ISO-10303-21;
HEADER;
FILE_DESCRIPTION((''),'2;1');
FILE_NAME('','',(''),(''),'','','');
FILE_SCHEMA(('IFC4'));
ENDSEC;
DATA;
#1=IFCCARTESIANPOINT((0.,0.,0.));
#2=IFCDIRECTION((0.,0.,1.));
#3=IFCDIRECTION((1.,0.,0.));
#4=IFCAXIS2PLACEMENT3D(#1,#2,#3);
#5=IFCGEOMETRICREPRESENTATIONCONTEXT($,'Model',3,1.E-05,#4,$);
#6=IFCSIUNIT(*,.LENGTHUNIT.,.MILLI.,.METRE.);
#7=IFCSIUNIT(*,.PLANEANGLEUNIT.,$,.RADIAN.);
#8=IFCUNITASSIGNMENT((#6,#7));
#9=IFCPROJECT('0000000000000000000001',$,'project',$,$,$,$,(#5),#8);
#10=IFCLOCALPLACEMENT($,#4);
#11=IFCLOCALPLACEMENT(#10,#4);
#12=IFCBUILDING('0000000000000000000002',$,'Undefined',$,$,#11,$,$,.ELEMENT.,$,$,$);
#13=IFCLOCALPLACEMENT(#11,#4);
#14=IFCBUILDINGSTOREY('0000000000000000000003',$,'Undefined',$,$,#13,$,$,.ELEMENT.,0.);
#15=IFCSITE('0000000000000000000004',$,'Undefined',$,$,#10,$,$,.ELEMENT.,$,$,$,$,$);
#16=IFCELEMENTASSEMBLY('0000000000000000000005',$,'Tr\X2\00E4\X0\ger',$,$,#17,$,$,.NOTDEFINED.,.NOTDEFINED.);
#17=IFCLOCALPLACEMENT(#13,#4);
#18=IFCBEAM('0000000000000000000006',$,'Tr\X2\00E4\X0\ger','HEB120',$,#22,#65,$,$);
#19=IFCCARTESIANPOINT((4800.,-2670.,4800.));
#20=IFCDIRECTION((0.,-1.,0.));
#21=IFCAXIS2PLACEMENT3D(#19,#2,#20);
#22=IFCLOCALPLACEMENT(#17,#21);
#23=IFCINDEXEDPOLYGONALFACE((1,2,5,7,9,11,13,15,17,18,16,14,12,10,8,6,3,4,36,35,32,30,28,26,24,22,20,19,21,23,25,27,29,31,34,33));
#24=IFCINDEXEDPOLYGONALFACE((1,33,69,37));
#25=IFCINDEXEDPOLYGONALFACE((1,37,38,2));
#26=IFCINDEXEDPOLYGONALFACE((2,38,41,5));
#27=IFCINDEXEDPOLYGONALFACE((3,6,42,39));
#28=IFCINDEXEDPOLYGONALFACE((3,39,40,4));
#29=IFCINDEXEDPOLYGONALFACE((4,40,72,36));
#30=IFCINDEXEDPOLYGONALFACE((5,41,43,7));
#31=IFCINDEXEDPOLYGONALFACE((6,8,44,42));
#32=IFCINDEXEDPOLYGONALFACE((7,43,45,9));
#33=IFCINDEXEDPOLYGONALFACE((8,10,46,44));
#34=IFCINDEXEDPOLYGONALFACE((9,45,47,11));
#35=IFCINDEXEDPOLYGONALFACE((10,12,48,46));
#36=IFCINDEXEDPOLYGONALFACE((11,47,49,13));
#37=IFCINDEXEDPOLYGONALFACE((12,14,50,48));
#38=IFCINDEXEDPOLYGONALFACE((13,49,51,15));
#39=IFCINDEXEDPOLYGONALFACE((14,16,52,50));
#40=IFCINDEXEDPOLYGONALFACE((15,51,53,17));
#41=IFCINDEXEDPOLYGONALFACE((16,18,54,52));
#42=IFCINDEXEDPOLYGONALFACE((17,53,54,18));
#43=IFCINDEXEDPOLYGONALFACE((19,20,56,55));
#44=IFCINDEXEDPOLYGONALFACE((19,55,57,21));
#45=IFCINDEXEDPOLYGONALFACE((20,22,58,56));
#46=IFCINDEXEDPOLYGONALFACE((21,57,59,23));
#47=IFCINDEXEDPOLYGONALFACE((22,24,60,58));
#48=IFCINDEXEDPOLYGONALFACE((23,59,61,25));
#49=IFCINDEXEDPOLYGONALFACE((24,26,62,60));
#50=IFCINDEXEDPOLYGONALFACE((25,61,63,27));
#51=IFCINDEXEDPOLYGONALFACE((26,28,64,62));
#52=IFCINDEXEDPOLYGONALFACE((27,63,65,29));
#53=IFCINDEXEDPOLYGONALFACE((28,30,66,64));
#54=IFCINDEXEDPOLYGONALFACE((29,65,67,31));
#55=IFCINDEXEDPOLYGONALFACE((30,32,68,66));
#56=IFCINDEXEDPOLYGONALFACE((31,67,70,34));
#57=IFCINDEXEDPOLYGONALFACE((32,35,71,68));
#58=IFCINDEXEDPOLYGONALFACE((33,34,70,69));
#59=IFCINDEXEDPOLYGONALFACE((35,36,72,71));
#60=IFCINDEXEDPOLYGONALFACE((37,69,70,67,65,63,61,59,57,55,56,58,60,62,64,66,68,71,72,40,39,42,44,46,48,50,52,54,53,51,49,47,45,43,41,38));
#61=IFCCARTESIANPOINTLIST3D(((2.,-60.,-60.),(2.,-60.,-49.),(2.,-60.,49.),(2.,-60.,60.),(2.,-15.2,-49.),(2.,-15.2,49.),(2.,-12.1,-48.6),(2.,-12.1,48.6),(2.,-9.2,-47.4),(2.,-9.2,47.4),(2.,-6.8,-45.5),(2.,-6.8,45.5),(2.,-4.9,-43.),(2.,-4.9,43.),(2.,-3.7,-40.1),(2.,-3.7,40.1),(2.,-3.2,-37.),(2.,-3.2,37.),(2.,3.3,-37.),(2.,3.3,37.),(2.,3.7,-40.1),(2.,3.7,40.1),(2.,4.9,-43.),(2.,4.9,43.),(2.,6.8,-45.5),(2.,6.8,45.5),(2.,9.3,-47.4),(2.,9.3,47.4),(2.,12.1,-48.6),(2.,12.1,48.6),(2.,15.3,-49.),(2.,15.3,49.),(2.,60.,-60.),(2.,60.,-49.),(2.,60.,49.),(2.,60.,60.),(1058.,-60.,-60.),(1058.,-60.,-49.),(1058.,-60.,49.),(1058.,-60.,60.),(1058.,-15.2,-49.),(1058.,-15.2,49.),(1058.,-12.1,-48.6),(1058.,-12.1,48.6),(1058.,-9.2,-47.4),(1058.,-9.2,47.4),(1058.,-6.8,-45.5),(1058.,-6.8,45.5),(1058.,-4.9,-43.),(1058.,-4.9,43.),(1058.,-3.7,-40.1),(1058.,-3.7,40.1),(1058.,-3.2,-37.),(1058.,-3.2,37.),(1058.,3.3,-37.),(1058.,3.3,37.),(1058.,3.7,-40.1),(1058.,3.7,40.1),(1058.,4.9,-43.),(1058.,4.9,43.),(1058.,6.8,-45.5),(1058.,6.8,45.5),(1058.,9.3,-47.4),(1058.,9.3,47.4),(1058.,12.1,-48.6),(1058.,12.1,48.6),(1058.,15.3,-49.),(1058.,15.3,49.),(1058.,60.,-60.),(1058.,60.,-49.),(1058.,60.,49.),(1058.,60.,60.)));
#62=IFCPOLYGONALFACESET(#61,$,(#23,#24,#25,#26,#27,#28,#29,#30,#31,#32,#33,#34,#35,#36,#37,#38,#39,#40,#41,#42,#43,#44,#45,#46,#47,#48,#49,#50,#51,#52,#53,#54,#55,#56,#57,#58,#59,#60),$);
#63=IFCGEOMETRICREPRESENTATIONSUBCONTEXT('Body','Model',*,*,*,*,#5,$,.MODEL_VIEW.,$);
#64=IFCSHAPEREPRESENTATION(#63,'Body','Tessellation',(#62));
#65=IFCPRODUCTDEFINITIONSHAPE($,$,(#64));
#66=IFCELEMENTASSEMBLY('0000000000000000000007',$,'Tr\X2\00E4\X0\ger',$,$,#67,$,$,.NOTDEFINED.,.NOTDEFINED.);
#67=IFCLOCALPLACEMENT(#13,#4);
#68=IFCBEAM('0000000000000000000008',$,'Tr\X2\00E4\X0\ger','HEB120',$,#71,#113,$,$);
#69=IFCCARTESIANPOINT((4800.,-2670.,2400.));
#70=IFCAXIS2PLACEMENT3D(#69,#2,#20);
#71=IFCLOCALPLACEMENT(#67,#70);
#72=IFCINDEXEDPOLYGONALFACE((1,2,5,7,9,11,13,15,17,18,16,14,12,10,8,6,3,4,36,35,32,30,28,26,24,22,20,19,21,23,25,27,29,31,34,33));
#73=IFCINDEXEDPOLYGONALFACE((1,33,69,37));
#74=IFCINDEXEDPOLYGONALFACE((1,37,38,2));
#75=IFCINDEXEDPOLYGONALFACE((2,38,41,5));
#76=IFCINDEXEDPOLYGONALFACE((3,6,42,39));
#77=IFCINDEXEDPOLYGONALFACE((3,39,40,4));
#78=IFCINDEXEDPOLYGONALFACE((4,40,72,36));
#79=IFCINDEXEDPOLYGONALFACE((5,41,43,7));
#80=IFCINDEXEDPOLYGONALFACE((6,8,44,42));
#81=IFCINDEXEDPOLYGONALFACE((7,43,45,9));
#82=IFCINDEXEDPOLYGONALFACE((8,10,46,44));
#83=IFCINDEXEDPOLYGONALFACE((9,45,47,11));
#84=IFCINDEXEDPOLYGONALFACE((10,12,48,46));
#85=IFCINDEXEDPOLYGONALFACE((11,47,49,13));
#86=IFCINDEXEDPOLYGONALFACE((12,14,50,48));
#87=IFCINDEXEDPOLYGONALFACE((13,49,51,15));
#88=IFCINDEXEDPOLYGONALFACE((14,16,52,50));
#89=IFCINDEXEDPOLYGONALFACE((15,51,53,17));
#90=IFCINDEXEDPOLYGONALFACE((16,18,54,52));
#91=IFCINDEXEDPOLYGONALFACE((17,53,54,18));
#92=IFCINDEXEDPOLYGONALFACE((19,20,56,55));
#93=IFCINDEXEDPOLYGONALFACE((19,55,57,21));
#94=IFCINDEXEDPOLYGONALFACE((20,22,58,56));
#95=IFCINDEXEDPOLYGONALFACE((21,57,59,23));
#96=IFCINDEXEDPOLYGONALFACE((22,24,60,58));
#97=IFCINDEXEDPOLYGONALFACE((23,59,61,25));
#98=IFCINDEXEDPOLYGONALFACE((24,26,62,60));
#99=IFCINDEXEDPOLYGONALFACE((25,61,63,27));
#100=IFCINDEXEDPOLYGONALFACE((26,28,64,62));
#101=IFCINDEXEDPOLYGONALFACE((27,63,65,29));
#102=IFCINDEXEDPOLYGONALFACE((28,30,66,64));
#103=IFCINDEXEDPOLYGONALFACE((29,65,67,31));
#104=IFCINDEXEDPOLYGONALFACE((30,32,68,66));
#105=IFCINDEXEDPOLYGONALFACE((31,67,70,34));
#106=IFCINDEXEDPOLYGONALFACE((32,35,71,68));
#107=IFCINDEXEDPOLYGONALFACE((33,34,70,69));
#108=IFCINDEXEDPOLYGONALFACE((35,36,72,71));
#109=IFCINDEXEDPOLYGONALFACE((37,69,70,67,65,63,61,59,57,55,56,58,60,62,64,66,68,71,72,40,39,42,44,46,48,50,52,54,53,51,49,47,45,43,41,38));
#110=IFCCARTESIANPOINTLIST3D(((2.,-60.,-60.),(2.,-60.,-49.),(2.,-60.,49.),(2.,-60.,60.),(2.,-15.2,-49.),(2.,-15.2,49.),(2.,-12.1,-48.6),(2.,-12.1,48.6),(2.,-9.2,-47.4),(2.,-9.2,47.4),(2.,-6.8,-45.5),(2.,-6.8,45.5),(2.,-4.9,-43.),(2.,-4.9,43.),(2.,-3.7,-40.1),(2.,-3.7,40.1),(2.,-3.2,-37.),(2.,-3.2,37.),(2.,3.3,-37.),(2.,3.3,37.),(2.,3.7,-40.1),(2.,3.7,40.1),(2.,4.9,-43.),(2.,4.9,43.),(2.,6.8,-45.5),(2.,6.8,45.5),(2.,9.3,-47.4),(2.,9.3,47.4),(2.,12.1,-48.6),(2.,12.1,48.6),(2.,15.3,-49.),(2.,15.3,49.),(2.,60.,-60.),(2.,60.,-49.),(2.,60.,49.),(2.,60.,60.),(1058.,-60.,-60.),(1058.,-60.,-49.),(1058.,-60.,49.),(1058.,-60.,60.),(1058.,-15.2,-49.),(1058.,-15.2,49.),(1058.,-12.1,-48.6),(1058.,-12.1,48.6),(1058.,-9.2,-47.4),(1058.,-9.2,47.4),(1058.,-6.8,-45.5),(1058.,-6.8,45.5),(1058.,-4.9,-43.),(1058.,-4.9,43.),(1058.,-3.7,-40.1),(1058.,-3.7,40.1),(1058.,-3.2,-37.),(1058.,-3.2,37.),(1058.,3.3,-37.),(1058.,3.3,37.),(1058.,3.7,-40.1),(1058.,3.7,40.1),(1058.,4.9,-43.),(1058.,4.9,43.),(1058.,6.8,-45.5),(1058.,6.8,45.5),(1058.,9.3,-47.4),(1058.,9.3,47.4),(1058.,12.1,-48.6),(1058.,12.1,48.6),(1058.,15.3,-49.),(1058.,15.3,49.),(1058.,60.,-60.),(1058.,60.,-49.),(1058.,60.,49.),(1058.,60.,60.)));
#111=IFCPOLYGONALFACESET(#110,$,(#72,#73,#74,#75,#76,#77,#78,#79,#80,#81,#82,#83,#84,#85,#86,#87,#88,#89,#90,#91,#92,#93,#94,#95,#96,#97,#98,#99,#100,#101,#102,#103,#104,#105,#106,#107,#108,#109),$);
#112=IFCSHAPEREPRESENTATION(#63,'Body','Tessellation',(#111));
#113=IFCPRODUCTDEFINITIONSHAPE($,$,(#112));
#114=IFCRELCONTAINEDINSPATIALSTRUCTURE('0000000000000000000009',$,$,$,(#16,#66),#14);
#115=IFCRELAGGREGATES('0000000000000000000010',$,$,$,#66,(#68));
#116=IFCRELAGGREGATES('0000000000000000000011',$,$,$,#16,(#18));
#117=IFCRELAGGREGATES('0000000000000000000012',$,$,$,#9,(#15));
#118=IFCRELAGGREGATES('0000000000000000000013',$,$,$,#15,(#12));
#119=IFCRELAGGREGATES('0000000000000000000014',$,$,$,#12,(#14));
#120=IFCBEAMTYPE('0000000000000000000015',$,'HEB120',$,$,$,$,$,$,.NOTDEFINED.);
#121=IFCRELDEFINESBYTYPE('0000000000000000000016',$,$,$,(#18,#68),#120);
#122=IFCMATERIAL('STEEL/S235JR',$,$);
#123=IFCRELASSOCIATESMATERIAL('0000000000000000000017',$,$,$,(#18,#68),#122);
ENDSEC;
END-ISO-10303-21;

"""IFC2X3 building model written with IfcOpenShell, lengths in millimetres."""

from ifc_helpers import new_model, si_unit, frame, origin_with_axes, origin_2d_with_axis, place, context, subcontext, project, spatial, i_section, extrude, clip, halfspace, material, type_object, element, aggregate, save


model = new_model("IFC2X3")

# Units and contexts
model_context = context("Model", 3, precision=1e-05, world=origin_with_axes())
body_context = subcontext(model_context, "Body", "Model", "MODEL_VIEW")
ifc_project = project(units=[si_unit("LENGTHUNIT", "METRE", prefix="MILLI"), si_unit("PLANEANGLEUNIT", "RADIAN")], contexts=[model_context])

# Site, building, storey
site_placement = place(None, origin_with_axes())
site = spatial("IfcSite", under=ifc_project, at=site_placement, Name="Undefined", CompositionType="ELEMENT")
building_placement = place(site_placement, origin_with_axes())
building = spatial("IfcBuilding", under=site, at=building_placement, Name="Undefined", CompositionType="ELEMENT")
storey_placement = place(building_placement, origin_with_axes())
storey = spatial("IfcBuildingStorey", under=building, at=storey_placement, Name="Undefined", CompositionType="ELEMENT", Elevation=0.0)

# Shared definitions
ifc_material_1 = material(Name="STEEL/S235JR")

# Shared definitions
beam_type_1 = type_object("IfcBeamType", Name="HEB120", PredefinedType="NOTDEFINED")

# Element assemblies, beams
assembly_1_placement = place(storey_placement, origin_with_axes())
assembly_1 = element("IfcElementAssembly", 1, at=assembly_1_placement, inside=storey, Name="Träger", AssemblyPlace="NOTDEFINED", PredefinedType="NOTDEFINED")
beam_1_placement = place(assembly_1_placement, frame((4800.0, -2670.0, 4800.0), z_axis=(0.0, 0.0, 1.0), x_axis=(0.0, -1.0, 0.0)))
beam_1 = element("IfcBeam", 2, at=beam_1_placement, type_object=beam_type_1, material=ifc_material_1, Name="Träger", Description="HEB120", context=body_context, shape_type="Clipping", body=[
    clip(clip(extrude(i_section(OverallWidth=120.0, OverallDepth=120.0, WebThickness=6.5, FlangeThickness=11.0, FilletRadius=12.0, at=origin_2d_with_axis()), frame((1060.0, 0.0, 0.0), z_axis=(-1.0, 0.0, 0.0), x_axis=(0.0, -1.0, 0.0)), (0.0, 0.0, 1.0), 1060.0), halfspace(frame((1058.0, 0.0, -60.0), z_axis=(-1.0, 0.0, 0.0), x_axis=(0.0, 1.0, 0.0)), True)), halfspace(frame((2.0, 0.0, -60.0), z_axis=(1.0, 0.0, 0.0), x_axis=(0.0, -1.0, 0.0)), True)),
])
assembly_2_placement = place(storey_placement, origin_with_axes())
assembly_2 = element("IfcElementAssembly", 3, at=assembly_2_placement, inside=storey, Name="Träger", AssemblyPlace="NOTDEFINED", PredefinedType="NOTDEFINED")
beam_2_placement = place(assembly_2_placement, frame((4800.0, -2670.0, 2400.0), z_axis=(0.0, 0.0, 1.0), x_axis=(0.0, -1.0, 0.0)))
beam_2 = element("IfcBeam", 4, at=beam_2_placement, type_object=beam_type_1, material=ifc_material_1, Name="Träger", Description="HEB120", context=body_context, shape_type="Clipping", body=[
    clip(clip(extrude(i_section(OverallWidth=120.0, OverallDepth=120.0, WebThickness=6.5, FlangeThickness=11.0, FilletRadius=12.0, at=origin_2d_with_axis()), frame((1060.0, 0.0, 0.0), z_axis=(-1.0, 0.0, 0.0), x_axis=(0.0, -1.0, 0.0)), (0.0, 0.0, 1.0), 1060.0), halfspace(frame((1058.0, 0.0, -60.0), z_axis=(-1.0, 0.0, 0.0), x_axis=(0.0, 1.0, 0.0)), True)), halfspace(frame((2.0, 0.0, -60.0), z_axis=(1.0, 0.0, 0.0), x_axis=(0.0, -1.0, 0.0)), True)),
])

aggregate(assembly_2, [beam_2])
aggregate(assembly_1, [beam_1])

save(model, "model.ifc")
